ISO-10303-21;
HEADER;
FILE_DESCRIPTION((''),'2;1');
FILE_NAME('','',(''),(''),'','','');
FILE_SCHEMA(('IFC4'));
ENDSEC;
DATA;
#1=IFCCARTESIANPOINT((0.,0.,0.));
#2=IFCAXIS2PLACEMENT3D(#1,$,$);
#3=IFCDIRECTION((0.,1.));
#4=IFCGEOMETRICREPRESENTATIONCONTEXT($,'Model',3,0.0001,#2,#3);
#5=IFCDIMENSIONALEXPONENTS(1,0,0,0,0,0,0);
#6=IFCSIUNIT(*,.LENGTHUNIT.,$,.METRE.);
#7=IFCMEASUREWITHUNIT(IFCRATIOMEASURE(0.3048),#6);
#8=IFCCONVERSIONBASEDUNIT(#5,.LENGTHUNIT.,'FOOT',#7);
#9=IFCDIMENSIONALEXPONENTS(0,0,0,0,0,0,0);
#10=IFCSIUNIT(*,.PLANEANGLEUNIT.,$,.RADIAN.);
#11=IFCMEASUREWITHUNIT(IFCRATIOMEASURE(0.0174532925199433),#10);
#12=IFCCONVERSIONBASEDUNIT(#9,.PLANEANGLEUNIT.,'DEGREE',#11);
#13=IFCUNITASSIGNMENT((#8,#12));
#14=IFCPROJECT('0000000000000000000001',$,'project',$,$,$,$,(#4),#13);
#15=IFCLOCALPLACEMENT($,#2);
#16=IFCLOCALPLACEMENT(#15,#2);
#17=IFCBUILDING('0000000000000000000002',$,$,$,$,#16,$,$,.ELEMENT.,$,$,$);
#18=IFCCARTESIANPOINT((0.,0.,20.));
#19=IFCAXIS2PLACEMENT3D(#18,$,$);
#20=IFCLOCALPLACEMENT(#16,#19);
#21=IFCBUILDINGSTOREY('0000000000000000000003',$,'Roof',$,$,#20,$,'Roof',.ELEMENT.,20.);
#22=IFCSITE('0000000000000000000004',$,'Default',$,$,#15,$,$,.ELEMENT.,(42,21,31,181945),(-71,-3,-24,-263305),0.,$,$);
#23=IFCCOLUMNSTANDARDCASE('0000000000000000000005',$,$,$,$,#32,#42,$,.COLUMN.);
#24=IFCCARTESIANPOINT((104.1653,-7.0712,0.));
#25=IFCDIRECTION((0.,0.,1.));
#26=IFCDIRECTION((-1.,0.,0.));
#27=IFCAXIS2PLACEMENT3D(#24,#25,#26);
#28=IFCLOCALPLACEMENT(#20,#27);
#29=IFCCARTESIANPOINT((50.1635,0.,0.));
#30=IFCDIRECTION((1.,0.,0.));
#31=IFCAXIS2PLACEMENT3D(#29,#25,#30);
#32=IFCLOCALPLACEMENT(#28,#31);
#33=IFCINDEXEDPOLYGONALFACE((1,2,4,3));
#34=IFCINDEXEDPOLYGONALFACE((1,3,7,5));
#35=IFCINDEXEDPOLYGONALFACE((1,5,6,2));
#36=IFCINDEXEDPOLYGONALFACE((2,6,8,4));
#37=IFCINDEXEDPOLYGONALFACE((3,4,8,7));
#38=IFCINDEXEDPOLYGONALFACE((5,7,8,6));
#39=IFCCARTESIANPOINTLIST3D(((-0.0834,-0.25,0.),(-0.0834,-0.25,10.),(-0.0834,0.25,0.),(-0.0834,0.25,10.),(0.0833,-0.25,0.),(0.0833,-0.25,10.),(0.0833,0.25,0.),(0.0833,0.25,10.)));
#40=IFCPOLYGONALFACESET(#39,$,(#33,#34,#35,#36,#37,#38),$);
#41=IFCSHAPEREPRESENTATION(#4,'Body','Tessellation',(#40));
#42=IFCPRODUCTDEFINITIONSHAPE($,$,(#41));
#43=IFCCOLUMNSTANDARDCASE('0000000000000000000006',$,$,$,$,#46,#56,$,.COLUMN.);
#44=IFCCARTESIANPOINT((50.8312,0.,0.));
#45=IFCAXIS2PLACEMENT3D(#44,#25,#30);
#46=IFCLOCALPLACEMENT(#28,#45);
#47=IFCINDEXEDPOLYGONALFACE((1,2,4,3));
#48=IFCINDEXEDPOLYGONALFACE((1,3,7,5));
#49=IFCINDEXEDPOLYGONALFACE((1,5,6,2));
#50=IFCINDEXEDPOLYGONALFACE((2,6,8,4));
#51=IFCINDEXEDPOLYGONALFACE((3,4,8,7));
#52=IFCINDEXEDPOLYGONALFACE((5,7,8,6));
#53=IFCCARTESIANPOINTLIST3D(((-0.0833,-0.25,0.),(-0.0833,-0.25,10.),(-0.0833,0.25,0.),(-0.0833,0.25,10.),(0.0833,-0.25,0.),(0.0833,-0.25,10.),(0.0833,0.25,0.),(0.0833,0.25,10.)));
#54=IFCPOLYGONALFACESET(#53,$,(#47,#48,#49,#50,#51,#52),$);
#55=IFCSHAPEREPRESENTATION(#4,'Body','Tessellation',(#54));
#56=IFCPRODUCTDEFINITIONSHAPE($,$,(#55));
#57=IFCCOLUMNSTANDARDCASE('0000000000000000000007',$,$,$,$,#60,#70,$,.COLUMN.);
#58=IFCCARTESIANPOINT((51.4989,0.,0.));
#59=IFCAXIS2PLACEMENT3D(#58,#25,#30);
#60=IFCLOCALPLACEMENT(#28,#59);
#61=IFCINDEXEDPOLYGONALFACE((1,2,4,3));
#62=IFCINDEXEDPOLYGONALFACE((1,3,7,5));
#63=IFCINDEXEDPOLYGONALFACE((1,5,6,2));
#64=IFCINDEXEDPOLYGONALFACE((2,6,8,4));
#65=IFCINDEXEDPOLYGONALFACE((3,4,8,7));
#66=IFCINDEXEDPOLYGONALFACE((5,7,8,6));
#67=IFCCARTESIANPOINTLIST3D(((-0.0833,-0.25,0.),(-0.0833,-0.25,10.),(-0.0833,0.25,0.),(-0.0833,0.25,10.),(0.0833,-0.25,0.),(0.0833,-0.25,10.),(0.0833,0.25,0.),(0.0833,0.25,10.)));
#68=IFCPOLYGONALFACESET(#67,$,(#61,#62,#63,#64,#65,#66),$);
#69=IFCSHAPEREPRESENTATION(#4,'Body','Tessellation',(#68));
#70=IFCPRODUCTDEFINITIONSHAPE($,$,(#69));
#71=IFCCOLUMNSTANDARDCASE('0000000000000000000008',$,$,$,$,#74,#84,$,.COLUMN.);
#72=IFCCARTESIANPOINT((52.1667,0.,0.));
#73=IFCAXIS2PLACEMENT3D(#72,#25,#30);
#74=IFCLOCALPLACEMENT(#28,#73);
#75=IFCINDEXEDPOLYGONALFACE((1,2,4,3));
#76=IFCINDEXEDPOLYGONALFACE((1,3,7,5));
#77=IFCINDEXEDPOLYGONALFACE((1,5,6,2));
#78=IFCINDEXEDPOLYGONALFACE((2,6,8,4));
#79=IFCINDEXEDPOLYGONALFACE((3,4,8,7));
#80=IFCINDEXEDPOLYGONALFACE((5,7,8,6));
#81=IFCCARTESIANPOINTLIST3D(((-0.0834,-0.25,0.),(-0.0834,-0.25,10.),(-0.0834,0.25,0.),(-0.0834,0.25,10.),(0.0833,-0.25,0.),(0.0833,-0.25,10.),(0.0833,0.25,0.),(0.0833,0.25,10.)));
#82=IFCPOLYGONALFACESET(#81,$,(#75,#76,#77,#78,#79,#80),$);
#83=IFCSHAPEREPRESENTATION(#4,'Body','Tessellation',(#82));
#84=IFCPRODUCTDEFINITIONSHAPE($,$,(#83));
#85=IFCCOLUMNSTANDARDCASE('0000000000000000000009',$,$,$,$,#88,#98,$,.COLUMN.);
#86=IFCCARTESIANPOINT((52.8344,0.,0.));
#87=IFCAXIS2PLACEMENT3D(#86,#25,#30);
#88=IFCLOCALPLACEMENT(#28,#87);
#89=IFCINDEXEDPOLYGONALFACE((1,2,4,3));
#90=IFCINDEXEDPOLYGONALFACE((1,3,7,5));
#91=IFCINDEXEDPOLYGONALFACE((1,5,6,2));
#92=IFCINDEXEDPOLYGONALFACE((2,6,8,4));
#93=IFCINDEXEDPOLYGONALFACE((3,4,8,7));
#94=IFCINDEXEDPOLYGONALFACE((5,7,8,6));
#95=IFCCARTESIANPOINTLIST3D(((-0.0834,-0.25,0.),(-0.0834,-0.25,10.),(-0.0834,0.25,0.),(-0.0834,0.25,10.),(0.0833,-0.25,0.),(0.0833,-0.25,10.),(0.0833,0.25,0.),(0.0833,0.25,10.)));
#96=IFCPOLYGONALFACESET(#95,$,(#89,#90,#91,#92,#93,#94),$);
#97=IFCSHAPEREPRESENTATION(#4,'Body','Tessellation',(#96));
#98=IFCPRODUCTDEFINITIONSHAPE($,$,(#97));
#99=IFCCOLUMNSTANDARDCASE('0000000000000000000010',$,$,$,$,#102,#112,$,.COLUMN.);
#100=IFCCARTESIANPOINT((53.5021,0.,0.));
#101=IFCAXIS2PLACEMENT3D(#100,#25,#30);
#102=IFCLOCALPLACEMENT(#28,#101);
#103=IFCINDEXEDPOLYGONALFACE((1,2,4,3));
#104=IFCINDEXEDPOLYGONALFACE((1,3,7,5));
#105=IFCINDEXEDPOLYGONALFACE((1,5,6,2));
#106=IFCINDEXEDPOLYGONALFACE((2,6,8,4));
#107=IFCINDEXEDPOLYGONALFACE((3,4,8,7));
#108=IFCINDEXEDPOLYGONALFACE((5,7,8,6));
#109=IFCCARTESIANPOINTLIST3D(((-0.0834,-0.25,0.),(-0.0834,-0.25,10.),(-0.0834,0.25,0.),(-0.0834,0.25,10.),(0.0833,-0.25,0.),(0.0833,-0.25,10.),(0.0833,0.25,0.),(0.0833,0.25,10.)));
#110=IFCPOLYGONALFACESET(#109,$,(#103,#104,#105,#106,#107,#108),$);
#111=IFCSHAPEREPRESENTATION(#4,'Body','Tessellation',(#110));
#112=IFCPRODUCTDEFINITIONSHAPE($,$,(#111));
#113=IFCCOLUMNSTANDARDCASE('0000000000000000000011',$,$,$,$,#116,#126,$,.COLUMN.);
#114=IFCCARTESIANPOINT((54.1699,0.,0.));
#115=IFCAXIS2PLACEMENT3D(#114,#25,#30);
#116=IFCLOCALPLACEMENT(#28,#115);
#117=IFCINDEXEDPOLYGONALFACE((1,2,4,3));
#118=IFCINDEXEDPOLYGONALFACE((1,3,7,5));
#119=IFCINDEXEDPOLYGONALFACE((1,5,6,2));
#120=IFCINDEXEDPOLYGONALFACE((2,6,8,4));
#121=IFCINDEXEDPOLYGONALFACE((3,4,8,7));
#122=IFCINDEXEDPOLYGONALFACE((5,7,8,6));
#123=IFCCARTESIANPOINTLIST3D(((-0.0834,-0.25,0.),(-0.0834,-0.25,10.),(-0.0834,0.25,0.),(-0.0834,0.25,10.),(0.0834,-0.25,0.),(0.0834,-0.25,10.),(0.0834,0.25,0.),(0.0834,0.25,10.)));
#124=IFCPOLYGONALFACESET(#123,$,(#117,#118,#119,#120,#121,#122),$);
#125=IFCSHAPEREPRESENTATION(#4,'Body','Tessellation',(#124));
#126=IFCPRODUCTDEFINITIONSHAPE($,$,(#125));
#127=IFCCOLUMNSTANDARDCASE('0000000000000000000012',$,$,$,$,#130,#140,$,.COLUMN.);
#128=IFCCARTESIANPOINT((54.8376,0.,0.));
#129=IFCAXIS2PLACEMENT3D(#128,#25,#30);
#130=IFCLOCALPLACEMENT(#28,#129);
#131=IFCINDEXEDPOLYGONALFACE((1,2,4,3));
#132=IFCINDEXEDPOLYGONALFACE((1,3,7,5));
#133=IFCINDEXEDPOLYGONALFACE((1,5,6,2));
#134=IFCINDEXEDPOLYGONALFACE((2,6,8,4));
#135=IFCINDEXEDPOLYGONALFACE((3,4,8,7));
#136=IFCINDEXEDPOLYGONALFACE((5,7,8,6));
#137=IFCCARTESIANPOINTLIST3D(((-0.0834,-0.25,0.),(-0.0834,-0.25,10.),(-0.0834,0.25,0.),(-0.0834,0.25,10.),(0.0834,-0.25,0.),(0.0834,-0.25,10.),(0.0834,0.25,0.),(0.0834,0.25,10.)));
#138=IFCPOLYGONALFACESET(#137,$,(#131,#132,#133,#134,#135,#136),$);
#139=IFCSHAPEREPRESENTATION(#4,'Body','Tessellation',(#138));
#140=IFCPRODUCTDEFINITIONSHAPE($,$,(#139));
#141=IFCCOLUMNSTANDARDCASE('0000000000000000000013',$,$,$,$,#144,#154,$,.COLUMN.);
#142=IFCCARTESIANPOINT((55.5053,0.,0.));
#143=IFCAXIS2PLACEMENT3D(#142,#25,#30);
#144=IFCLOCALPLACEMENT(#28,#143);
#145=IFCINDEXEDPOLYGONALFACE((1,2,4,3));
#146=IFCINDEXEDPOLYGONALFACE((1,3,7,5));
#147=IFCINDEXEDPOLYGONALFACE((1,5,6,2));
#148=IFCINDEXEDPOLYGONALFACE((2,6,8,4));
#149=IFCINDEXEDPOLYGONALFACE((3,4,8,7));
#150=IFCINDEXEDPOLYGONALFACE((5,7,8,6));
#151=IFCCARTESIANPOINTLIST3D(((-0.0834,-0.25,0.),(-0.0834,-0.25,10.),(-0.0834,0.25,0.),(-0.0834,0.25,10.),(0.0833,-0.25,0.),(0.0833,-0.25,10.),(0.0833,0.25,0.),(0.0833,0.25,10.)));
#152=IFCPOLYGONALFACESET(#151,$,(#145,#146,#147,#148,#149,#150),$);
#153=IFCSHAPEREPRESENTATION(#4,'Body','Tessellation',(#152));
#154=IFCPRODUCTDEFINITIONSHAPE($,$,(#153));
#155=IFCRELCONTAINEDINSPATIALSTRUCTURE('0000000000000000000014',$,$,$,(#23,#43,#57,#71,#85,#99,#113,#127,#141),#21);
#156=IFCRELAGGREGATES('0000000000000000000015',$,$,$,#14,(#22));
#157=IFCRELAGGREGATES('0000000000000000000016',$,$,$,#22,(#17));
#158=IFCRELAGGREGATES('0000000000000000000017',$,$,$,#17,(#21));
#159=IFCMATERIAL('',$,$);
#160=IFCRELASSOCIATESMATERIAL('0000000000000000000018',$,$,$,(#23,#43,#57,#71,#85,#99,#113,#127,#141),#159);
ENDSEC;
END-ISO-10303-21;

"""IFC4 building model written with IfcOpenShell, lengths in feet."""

from ifc_helpers import new_model, entity, si_unit, converted_unit, direction, frame, origin, place, context, project, spatial, rectangle, extrude, material, element, save


model = new_model("IFC4")

# Units and contexts
model_context = context("Model", 3, precision=0.0001, world=origin(), true_north=direction((0.0, 1.0)))
ifc_project = project(units=[converted_unit("LENGTHUNIT", "FOOT", entity("IfcRatioMeasure", 0.3048), si_unit("LENGTHUNIT", "METRE"), dimensions=[1, 0, 0, 0, 0, 0, 0]), converted_unit("PLANEANGLEUNIT", "DEGREE", entity("IfcRatioMeasure", 0.0174532925199433), si_unit("PLANEANGLEUNIT", "RADIAN"), dimensions=[0, 0, 0, 0, 0, 0, 0])], contexts=[model_context])

# Site, building, storey
site_placement = place(None, origin())
site = spatial("IfcSite", under=ifc_project, at=site_placement, Name="Default", CompositionType="ELEMENT", RefLatitude=(42, 21, 31, 181945), RefLongitude=(-71, -3, -24, -263305), RefElevation=0.0)
building_placement = place(site_placement, origin())
building = spatial("IfcBuilding", under=site, at=building_placement, CompositionType="ELEMENT")
storey_placement = place(building_placement, frame((0.0, 0.0, 20.0)))
storey = spatial("IfcBuildingStorey", under=building, at=storey_placement, Name="Roof", LongName="Roof", CompositionType="ELEMENT", Elevation=20.0)

# Columns
ifc_material_1 = material(Name="")
placement = place(storey_placement, frame((104.1653, -7.0712, 0.0), z_axis=(0.0, 0.0, 1.0), x_axis=(-1.0, 0.0, 0.0)))
for number, where, z_axis, x_axis in (
    (1, (50.1635, 0.0, 0.0), (0.0, 0.0, 1.0), (1.0, 0.0, 0.0)),
    (2, (50.8312, 0.0, 0.0), (0.0, 0.0, 1.0), (1.0, 0.0, 0.0)),
    (3, (51.4989, 0.0, 0.0), (0.0, 0.0, 1.0), (1.0, 0.0, 0.0)),
    (4, (52.1667, 0.0, 0.0), (0.0, 0.0, 1.0), (1.0, 0.0, 0.0)),
    (5, (52.8344, 0.0, 0.0), (0.0, 0.0, 1.0), (1.0, 0.0, 0.0)),
    (6, (53.5021, 0.0, 0.0), (0.0, 0.0, 1.0), (1.0, 0.0, 0.0)),
    (7, (54.1699, 0.0, 0.0), (0.0, 0.0, 1.0), (1.0, 0.0, 0.0)),
    (8, (54.8376, 0.0, 0.0), (0.0, 0.0, 1.0), (1.0, 0.0, 0.0)),
    (9, (55.5053, 0.0, 0.0), (0.0, 0.0, 1.0), (1.0, 0.0, 0.0)),
):
    element("IfcColumnStandardCase", number, at=place(placement, frame(where, z_axis=z_axis, x_axis=x_axis)), inside=storey, material=ifc_material_1, PredefinedType="COLUMN", context=model_context, shape_type="SweptSolid", body=[
        extrude(rectangle(XDim=0.1667, YDim=0.5), origin(), (0.0, 0.0, 1.0), 10.0),
    ])

save(model, "model.ifc")
